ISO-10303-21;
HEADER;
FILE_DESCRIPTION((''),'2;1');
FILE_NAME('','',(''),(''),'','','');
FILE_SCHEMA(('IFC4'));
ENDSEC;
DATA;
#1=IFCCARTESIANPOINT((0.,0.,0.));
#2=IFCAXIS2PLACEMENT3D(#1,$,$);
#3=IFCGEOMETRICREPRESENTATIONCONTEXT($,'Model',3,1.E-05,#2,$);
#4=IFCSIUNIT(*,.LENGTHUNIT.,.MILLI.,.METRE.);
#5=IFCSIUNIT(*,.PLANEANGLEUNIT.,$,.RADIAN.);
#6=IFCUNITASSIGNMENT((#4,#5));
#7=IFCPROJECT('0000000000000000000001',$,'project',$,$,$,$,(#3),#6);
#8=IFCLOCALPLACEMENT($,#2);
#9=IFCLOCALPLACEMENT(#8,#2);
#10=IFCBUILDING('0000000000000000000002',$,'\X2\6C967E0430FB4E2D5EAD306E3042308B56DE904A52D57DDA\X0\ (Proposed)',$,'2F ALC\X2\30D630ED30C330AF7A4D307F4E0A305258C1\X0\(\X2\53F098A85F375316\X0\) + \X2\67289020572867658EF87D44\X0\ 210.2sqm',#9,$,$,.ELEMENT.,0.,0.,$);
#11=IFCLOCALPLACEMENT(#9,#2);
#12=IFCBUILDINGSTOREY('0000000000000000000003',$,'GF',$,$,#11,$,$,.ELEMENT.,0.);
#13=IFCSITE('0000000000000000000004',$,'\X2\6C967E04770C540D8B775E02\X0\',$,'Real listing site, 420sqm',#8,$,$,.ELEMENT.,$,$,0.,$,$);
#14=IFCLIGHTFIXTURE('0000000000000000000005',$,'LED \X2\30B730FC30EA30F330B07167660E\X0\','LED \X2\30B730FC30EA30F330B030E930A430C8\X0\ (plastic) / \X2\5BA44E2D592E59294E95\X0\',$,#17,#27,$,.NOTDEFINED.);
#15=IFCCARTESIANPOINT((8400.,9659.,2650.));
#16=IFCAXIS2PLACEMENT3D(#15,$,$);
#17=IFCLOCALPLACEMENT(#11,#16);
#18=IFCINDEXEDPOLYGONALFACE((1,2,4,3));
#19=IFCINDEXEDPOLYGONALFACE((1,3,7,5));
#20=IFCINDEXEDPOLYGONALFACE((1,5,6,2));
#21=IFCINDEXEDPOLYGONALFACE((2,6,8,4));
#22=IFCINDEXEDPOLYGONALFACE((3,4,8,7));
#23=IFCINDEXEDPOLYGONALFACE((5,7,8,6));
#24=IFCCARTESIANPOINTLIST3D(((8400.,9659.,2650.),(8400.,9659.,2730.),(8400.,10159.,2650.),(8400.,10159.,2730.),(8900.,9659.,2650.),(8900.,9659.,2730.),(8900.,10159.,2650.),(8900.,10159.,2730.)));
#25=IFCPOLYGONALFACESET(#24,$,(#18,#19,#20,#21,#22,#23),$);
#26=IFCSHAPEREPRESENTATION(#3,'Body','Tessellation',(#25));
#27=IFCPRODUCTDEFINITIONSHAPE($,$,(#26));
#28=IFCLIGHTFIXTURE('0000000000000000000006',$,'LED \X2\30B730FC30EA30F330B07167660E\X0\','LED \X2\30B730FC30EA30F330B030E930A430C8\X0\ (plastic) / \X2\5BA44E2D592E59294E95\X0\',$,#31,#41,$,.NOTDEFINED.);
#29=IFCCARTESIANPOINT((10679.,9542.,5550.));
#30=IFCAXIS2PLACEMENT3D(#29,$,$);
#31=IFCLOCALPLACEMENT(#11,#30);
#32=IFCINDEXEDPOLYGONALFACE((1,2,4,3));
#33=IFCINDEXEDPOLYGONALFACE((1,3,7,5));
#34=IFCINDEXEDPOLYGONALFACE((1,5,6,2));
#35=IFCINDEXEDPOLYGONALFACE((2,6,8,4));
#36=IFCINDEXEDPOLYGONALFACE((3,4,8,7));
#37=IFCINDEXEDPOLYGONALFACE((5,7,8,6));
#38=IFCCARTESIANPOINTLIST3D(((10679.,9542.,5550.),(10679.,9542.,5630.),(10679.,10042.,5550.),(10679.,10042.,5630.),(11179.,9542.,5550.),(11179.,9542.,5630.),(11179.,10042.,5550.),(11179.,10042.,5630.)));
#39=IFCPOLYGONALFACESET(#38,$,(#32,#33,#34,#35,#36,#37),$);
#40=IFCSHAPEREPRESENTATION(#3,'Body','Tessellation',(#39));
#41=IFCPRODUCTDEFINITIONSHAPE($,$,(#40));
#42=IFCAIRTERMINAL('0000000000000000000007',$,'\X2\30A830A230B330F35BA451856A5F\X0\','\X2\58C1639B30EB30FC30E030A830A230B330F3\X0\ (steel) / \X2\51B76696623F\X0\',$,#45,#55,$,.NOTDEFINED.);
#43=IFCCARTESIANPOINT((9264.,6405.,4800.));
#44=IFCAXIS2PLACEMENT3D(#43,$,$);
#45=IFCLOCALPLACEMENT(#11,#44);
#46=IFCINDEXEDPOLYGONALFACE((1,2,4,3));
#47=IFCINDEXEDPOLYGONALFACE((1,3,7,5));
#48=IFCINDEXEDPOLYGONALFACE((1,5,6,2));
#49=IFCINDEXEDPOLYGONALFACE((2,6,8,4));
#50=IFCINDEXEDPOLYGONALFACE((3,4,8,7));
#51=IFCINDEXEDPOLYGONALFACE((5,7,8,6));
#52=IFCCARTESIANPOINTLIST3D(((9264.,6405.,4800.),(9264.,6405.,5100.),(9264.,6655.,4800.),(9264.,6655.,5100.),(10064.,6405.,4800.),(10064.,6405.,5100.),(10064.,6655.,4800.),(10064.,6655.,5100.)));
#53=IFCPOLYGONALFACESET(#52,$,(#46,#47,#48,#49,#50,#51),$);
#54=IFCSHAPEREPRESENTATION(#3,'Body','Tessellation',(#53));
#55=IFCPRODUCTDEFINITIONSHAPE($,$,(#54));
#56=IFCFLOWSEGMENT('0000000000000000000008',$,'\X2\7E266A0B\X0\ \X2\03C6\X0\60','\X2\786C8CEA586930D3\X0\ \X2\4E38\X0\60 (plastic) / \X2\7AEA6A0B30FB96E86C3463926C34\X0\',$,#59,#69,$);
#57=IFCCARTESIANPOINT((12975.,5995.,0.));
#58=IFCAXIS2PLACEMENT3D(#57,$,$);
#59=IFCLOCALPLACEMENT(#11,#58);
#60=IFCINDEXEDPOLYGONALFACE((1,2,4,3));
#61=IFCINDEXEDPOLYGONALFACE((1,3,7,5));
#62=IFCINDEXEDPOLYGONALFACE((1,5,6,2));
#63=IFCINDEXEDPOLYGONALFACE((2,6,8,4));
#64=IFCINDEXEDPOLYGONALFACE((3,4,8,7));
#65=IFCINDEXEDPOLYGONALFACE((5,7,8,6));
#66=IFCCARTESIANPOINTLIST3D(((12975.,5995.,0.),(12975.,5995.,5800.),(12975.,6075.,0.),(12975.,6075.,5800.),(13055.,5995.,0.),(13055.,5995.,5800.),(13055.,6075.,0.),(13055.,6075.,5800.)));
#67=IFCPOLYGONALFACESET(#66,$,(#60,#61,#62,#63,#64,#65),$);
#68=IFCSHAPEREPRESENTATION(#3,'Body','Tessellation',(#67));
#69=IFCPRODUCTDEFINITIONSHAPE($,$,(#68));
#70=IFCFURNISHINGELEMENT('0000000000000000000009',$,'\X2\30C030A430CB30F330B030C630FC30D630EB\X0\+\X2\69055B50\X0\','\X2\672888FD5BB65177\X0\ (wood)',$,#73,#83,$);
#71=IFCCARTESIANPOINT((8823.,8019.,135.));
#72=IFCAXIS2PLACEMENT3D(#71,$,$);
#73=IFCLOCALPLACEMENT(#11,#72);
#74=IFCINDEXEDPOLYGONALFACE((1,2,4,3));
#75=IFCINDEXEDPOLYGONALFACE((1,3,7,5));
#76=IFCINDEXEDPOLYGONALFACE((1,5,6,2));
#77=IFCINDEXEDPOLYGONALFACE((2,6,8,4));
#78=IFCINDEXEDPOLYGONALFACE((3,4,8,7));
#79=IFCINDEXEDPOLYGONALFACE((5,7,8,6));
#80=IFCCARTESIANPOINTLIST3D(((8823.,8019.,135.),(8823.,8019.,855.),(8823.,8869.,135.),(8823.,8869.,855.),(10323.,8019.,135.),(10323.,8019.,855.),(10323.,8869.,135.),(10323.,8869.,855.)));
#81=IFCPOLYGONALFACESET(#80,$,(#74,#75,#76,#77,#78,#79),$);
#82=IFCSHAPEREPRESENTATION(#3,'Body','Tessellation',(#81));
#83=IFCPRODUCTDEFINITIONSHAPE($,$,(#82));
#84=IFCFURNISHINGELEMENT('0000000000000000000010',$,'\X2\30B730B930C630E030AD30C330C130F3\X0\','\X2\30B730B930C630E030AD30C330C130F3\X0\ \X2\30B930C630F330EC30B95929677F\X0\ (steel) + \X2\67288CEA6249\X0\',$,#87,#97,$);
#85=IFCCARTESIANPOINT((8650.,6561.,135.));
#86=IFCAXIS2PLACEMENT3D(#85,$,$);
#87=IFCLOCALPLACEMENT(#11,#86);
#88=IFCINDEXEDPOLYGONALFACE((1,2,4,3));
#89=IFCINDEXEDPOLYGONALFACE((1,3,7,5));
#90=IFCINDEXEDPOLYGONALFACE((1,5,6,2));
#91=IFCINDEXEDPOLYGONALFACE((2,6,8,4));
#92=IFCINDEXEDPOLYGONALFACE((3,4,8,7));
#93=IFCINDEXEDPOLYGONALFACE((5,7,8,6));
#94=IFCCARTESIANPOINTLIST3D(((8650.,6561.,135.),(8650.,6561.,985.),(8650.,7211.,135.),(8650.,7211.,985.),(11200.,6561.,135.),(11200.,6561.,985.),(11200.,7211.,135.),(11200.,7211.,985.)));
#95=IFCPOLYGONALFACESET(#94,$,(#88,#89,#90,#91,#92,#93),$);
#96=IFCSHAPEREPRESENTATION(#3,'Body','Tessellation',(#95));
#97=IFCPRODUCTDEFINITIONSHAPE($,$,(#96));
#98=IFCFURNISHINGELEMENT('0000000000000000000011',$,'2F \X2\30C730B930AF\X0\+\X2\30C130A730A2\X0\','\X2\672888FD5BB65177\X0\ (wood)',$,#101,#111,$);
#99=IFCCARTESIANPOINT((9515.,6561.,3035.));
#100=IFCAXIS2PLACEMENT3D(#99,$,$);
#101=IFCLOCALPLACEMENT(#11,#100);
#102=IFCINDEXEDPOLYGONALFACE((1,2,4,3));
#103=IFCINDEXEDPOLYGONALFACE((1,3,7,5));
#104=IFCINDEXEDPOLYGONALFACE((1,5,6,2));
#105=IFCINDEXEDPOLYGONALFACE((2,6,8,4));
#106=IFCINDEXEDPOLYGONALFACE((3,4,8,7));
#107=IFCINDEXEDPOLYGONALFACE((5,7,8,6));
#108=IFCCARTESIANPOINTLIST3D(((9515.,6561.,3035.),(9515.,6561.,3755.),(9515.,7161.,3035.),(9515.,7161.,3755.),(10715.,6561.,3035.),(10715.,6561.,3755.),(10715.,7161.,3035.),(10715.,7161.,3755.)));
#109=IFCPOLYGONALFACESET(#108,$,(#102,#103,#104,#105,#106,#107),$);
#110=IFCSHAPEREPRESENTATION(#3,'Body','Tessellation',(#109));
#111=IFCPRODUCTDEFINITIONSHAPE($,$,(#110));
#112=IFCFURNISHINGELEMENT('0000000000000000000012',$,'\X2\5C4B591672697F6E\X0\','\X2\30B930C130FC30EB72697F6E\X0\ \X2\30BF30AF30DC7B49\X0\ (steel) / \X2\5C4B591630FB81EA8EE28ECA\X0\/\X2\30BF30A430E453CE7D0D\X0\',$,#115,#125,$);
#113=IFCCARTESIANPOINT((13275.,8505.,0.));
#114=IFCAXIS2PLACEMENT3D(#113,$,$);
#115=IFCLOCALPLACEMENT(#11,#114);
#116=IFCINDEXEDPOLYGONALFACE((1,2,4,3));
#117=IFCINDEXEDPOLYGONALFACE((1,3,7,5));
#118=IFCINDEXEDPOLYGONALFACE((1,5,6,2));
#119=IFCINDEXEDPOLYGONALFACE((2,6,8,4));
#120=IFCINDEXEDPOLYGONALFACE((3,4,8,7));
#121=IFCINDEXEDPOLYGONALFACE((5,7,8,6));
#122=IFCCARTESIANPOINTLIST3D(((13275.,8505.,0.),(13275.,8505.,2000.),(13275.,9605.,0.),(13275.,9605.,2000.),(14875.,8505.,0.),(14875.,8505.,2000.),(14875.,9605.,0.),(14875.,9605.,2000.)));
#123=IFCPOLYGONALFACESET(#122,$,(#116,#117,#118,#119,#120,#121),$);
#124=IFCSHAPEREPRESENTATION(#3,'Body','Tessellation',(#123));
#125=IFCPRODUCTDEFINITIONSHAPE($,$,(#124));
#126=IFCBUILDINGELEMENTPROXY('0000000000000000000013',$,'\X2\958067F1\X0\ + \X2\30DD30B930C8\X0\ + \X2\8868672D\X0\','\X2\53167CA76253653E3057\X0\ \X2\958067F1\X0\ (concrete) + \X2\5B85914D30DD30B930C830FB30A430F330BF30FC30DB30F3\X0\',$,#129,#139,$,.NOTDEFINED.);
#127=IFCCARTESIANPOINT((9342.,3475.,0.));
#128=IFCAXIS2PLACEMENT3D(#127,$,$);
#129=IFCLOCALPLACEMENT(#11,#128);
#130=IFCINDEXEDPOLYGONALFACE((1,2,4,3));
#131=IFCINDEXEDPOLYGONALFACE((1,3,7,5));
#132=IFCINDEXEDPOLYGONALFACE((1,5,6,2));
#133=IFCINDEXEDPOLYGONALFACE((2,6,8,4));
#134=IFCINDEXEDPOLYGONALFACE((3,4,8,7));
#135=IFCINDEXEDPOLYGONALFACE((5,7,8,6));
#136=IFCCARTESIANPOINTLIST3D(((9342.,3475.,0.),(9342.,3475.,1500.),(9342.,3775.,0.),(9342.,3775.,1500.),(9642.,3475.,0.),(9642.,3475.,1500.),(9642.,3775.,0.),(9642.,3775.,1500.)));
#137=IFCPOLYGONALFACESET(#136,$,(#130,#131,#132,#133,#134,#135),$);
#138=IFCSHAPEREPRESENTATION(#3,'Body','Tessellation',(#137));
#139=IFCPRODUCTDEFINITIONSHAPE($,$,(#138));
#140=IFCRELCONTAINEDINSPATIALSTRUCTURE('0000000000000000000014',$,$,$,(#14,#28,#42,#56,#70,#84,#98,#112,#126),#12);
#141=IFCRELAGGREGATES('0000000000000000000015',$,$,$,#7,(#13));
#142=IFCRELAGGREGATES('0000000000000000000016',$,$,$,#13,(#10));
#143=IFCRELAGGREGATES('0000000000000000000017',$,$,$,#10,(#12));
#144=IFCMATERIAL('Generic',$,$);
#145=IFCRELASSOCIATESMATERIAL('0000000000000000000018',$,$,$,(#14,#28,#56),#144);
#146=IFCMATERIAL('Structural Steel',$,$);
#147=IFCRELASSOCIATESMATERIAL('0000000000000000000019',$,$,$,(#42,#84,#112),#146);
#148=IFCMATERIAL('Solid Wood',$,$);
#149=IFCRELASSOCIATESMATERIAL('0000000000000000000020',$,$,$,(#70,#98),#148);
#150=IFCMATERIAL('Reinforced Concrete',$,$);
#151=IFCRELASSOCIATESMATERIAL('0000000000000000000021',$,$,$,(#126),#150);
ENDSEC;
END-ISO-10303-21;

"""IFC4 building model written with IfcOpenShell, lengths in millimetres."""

from ifc_helpers import new_model, si_unit, frame, frame_2d, origin, place, context, project, spatial, rectangle, extrude, material, element, save


model = new_model("IFC4")

# Units and contexts
model_context = context("Model", 3, precision=1e-05, world=origin())
ifc_project = project(units=[si_unit("LENGTHUNIT", "METRE", prefix="MILLI"), si_unit("PLANEANGLEUNIT", "RADIAN")], contexts=[model_context])

# Site, building, storey
site_placement = place(None, origin())
site = spatial("IfcSite", under=ifc_project, at=site_placement, Name="沖縄県名護市", ObjectType="Real listing site, 420sqm", CompositionType="ELEMENT", RefElevation=0.0)
building_placement = place(site_placement, origin())
building = spatial("IfcBuilding", under=site, at=building_placement, Name="沖縄・中庭のある回遊動線 (Proposed)", ObjectType="2F ALCブロック積み上げ壁(台風強化) + 木造在来軸組 210.2sqm", CompositionType="ELEMENT", ElevationOfRefHeight=0.0, ElevationOfTerrain=0.0)
storey_placement = place(building_placement, origin())
storey = spatial("IfcBuildingStorey", under=building, at=storey_placement, Name="GF", CompositionType="ELEMENT", Elevation=0.0)

# Shared definitions
ifc_material_1 = material(Name="Solid Wood")

# Shared definitions
ifc_material_2 = material(Name="Reinforced Concrete")

# Shared definitions
ifc_material_3 = material(Name="Structural Steel")

# Shared definitions
ifc_material_4 = material(Name="Generic")

# Light fixtures
light_fixture_1_placement = place(storey_placement, frame((8400.0, 9659.0, 2650.0)))
element("IfcLightFixture", 1, at=light_fixture_1_placement, inside=storey, material=ifc_material_4, Name="LED シーリング照明", Description="LED シーリングライト (plastic) / 室中央天井", PredefinedType="NOTDEFINED", context=model_context, shape_type="SweptSolid", body=[
    extrude(rectangle(XDim=500.0, YDim=500.0, at=frame_2d((250.0, 250.0))), frame((8400.0, 9659.0, 2650.0)), (0.0, 0.0, 1.0), 80.0),
])
light_fixture_2_placement = place(storey_placement, frame((10679.0, 9542.0, 5550.0)))
element("IfcLightFixture", 2, at=light_fixture_2_placement, inside=storey, material=ifc_material_4, Name="LED シーリング照明", Description="LED シーリングライト (plastic) / 室中央天井", PredefinedType="NOTDEFINED", context=model_context, shape_type="SweptSolid", body=[
    extrude(rectangle(XDim=500.0, YDim=500.0, at=frame_2d((250.0, 250.0))), frame((10679.0, 9542.0, 5550.0)), (0.0, 0.0, 1.0), 80.0),
])

# Air terminal
air_terminal_placement = place(storey_placement, frame((9264.0, 6405.0, 4800.0)))
element("IfcAirTerminal", 3, at=air_terminal_placement, inside=storey, material=ifc_material_3, Name="エアコン室内機", Description="壁掛ルームエアコン (steel) / 冷暖房", PredefinedType="NOTDEFINED", context=model_context, shape_type="SweptSolid", body=[
    extrude(rectangle(XDim=800.0, YDim=250.0, at=frame_2d((400.0, 125.0))), frame((9264.0, 6405.0, 4800.0)), (0.0, 0.0, 1.0), 300.0),
])

# Flow segment
flow_segment_placement = place(storey_placement, frame((12975.0, 5995.0, 0.0)))
element("IfcFlowSegment", 4, at=flow_segment_placement, inside=storey, material=ifc_material_4, Name="縦樋 φ60", Description="硬質塩ビ 丸60 (plastic) / 竪樋・雨水排水", context=model_context, shape_type="SweptSolid", body=[
    extrude(rectangle(XDim=80.0, YDim=80.0, at=frame_2d((40.0, 40.0))), frame((12975.0, 5995.0, 0.0)), (0.0, 0.0, 1.0), 5800.0),
])

# Furnishing elements
furnishing_1_placement = place(storey_placement, frame((8823.0, 8019.0, 135.0)))
element("IfcFurnishingElement", 5, at=furnishing_1_placement, inside=storey, material=ifc_material_1, Name="ダイニングテーブル+椅子", Description="木製家具 (wood)", context=model_context, shape_type="SweptSolid", body=[
    extrude(rectangle(XDim=1500.0, YDim=850.0, at=frame_2d((750.0, 425.0))), frame((8823.0, 8019.0, 135.0)), (0.0, 0.0, 1.0), 720.0),
])
furnishing_2_placement = place(storey_placement, frame((8650.0, 6561.0, 135.0)))
element("IfcFurnishingElement", 6, at=furnishing_2_placement, inside=storey, material=ifc_material_3, Name="システムキッチン", Description="システムキッチン ステンレス天板 (steel) + 木質扉", context=model_context, shape_type="SweptSolid", body=[
    extrude(rectangle(XDim=2550.0, YDim=650.0, at=frame_2d((1275.0, 325.0))), frame((8650.0, 6561.0, 135.0)), (0.0, 0.0, 1.0), 850.0),
])
furnishing_3_placement = place(storey_placement, frame((9515.0, 6561.0, 3035.0)))
element("IfcFurnishingElement", 7, at=furnishing_3_placement, inside=storey, material=ifc_material_1, Name="2F デスク+チェア", Description="木製家具 (wood)", context=model_context, shape_type="SweptSolid", body=[
    extrude(rectangle(XDim=1200.0, YDim=600.0, at=frame_2d((600.0, 300.0))), frame((9515.0, 6561.0, 3035.0)), (0.0, 0.0, 1.0), 720.0),
])
furnishing_4_placement = place(storey_placement, frame((13275.0, 8505.0, 0.0)))
element("IfcFurnishingElement", 8, at=furnishing_4_placement, inside=storey, material=ifc_material_3, Name="屋外物置", Description="スチール物置 タクボ等 (steel) / 屋外・自転車/タイヤ収納", context=model_context, shape_type="SweptSolid", body=[
    extrude(rectangle(XDim=1600.0, YDim=1100.0, at=frame_2d((800.0, 550.0))), frame((13275.0, 8505.0, 0.0)), (0.0, 0.0, 1.0), 2000.0),
])

# Building element proxy
proxy_placement = place(storey_placement, frame((9342.0, 3475.0, 0.0)))
element("IfcBuildingElementProxy", 9, at=proxy_placement, inside=storey, material=ifc_material_2, Name="門柱 + ポスト + 表札", Description="化粧打放し 門柱 (concrete) + 宅配ポスト・インターホン", PredefinedType="NOTDEFINED", context=model_context, shape_type="SweptSolid", body=[
    extrude(rectangle(XDim=300.0, YDim=300.0, at=frame_2d((150.0, 150.0))), frame((9342.0, 3475.0, 0.0)), (0.0, 0.0, 1.0), 1500.0),
])

save(model, "model.ifc")
